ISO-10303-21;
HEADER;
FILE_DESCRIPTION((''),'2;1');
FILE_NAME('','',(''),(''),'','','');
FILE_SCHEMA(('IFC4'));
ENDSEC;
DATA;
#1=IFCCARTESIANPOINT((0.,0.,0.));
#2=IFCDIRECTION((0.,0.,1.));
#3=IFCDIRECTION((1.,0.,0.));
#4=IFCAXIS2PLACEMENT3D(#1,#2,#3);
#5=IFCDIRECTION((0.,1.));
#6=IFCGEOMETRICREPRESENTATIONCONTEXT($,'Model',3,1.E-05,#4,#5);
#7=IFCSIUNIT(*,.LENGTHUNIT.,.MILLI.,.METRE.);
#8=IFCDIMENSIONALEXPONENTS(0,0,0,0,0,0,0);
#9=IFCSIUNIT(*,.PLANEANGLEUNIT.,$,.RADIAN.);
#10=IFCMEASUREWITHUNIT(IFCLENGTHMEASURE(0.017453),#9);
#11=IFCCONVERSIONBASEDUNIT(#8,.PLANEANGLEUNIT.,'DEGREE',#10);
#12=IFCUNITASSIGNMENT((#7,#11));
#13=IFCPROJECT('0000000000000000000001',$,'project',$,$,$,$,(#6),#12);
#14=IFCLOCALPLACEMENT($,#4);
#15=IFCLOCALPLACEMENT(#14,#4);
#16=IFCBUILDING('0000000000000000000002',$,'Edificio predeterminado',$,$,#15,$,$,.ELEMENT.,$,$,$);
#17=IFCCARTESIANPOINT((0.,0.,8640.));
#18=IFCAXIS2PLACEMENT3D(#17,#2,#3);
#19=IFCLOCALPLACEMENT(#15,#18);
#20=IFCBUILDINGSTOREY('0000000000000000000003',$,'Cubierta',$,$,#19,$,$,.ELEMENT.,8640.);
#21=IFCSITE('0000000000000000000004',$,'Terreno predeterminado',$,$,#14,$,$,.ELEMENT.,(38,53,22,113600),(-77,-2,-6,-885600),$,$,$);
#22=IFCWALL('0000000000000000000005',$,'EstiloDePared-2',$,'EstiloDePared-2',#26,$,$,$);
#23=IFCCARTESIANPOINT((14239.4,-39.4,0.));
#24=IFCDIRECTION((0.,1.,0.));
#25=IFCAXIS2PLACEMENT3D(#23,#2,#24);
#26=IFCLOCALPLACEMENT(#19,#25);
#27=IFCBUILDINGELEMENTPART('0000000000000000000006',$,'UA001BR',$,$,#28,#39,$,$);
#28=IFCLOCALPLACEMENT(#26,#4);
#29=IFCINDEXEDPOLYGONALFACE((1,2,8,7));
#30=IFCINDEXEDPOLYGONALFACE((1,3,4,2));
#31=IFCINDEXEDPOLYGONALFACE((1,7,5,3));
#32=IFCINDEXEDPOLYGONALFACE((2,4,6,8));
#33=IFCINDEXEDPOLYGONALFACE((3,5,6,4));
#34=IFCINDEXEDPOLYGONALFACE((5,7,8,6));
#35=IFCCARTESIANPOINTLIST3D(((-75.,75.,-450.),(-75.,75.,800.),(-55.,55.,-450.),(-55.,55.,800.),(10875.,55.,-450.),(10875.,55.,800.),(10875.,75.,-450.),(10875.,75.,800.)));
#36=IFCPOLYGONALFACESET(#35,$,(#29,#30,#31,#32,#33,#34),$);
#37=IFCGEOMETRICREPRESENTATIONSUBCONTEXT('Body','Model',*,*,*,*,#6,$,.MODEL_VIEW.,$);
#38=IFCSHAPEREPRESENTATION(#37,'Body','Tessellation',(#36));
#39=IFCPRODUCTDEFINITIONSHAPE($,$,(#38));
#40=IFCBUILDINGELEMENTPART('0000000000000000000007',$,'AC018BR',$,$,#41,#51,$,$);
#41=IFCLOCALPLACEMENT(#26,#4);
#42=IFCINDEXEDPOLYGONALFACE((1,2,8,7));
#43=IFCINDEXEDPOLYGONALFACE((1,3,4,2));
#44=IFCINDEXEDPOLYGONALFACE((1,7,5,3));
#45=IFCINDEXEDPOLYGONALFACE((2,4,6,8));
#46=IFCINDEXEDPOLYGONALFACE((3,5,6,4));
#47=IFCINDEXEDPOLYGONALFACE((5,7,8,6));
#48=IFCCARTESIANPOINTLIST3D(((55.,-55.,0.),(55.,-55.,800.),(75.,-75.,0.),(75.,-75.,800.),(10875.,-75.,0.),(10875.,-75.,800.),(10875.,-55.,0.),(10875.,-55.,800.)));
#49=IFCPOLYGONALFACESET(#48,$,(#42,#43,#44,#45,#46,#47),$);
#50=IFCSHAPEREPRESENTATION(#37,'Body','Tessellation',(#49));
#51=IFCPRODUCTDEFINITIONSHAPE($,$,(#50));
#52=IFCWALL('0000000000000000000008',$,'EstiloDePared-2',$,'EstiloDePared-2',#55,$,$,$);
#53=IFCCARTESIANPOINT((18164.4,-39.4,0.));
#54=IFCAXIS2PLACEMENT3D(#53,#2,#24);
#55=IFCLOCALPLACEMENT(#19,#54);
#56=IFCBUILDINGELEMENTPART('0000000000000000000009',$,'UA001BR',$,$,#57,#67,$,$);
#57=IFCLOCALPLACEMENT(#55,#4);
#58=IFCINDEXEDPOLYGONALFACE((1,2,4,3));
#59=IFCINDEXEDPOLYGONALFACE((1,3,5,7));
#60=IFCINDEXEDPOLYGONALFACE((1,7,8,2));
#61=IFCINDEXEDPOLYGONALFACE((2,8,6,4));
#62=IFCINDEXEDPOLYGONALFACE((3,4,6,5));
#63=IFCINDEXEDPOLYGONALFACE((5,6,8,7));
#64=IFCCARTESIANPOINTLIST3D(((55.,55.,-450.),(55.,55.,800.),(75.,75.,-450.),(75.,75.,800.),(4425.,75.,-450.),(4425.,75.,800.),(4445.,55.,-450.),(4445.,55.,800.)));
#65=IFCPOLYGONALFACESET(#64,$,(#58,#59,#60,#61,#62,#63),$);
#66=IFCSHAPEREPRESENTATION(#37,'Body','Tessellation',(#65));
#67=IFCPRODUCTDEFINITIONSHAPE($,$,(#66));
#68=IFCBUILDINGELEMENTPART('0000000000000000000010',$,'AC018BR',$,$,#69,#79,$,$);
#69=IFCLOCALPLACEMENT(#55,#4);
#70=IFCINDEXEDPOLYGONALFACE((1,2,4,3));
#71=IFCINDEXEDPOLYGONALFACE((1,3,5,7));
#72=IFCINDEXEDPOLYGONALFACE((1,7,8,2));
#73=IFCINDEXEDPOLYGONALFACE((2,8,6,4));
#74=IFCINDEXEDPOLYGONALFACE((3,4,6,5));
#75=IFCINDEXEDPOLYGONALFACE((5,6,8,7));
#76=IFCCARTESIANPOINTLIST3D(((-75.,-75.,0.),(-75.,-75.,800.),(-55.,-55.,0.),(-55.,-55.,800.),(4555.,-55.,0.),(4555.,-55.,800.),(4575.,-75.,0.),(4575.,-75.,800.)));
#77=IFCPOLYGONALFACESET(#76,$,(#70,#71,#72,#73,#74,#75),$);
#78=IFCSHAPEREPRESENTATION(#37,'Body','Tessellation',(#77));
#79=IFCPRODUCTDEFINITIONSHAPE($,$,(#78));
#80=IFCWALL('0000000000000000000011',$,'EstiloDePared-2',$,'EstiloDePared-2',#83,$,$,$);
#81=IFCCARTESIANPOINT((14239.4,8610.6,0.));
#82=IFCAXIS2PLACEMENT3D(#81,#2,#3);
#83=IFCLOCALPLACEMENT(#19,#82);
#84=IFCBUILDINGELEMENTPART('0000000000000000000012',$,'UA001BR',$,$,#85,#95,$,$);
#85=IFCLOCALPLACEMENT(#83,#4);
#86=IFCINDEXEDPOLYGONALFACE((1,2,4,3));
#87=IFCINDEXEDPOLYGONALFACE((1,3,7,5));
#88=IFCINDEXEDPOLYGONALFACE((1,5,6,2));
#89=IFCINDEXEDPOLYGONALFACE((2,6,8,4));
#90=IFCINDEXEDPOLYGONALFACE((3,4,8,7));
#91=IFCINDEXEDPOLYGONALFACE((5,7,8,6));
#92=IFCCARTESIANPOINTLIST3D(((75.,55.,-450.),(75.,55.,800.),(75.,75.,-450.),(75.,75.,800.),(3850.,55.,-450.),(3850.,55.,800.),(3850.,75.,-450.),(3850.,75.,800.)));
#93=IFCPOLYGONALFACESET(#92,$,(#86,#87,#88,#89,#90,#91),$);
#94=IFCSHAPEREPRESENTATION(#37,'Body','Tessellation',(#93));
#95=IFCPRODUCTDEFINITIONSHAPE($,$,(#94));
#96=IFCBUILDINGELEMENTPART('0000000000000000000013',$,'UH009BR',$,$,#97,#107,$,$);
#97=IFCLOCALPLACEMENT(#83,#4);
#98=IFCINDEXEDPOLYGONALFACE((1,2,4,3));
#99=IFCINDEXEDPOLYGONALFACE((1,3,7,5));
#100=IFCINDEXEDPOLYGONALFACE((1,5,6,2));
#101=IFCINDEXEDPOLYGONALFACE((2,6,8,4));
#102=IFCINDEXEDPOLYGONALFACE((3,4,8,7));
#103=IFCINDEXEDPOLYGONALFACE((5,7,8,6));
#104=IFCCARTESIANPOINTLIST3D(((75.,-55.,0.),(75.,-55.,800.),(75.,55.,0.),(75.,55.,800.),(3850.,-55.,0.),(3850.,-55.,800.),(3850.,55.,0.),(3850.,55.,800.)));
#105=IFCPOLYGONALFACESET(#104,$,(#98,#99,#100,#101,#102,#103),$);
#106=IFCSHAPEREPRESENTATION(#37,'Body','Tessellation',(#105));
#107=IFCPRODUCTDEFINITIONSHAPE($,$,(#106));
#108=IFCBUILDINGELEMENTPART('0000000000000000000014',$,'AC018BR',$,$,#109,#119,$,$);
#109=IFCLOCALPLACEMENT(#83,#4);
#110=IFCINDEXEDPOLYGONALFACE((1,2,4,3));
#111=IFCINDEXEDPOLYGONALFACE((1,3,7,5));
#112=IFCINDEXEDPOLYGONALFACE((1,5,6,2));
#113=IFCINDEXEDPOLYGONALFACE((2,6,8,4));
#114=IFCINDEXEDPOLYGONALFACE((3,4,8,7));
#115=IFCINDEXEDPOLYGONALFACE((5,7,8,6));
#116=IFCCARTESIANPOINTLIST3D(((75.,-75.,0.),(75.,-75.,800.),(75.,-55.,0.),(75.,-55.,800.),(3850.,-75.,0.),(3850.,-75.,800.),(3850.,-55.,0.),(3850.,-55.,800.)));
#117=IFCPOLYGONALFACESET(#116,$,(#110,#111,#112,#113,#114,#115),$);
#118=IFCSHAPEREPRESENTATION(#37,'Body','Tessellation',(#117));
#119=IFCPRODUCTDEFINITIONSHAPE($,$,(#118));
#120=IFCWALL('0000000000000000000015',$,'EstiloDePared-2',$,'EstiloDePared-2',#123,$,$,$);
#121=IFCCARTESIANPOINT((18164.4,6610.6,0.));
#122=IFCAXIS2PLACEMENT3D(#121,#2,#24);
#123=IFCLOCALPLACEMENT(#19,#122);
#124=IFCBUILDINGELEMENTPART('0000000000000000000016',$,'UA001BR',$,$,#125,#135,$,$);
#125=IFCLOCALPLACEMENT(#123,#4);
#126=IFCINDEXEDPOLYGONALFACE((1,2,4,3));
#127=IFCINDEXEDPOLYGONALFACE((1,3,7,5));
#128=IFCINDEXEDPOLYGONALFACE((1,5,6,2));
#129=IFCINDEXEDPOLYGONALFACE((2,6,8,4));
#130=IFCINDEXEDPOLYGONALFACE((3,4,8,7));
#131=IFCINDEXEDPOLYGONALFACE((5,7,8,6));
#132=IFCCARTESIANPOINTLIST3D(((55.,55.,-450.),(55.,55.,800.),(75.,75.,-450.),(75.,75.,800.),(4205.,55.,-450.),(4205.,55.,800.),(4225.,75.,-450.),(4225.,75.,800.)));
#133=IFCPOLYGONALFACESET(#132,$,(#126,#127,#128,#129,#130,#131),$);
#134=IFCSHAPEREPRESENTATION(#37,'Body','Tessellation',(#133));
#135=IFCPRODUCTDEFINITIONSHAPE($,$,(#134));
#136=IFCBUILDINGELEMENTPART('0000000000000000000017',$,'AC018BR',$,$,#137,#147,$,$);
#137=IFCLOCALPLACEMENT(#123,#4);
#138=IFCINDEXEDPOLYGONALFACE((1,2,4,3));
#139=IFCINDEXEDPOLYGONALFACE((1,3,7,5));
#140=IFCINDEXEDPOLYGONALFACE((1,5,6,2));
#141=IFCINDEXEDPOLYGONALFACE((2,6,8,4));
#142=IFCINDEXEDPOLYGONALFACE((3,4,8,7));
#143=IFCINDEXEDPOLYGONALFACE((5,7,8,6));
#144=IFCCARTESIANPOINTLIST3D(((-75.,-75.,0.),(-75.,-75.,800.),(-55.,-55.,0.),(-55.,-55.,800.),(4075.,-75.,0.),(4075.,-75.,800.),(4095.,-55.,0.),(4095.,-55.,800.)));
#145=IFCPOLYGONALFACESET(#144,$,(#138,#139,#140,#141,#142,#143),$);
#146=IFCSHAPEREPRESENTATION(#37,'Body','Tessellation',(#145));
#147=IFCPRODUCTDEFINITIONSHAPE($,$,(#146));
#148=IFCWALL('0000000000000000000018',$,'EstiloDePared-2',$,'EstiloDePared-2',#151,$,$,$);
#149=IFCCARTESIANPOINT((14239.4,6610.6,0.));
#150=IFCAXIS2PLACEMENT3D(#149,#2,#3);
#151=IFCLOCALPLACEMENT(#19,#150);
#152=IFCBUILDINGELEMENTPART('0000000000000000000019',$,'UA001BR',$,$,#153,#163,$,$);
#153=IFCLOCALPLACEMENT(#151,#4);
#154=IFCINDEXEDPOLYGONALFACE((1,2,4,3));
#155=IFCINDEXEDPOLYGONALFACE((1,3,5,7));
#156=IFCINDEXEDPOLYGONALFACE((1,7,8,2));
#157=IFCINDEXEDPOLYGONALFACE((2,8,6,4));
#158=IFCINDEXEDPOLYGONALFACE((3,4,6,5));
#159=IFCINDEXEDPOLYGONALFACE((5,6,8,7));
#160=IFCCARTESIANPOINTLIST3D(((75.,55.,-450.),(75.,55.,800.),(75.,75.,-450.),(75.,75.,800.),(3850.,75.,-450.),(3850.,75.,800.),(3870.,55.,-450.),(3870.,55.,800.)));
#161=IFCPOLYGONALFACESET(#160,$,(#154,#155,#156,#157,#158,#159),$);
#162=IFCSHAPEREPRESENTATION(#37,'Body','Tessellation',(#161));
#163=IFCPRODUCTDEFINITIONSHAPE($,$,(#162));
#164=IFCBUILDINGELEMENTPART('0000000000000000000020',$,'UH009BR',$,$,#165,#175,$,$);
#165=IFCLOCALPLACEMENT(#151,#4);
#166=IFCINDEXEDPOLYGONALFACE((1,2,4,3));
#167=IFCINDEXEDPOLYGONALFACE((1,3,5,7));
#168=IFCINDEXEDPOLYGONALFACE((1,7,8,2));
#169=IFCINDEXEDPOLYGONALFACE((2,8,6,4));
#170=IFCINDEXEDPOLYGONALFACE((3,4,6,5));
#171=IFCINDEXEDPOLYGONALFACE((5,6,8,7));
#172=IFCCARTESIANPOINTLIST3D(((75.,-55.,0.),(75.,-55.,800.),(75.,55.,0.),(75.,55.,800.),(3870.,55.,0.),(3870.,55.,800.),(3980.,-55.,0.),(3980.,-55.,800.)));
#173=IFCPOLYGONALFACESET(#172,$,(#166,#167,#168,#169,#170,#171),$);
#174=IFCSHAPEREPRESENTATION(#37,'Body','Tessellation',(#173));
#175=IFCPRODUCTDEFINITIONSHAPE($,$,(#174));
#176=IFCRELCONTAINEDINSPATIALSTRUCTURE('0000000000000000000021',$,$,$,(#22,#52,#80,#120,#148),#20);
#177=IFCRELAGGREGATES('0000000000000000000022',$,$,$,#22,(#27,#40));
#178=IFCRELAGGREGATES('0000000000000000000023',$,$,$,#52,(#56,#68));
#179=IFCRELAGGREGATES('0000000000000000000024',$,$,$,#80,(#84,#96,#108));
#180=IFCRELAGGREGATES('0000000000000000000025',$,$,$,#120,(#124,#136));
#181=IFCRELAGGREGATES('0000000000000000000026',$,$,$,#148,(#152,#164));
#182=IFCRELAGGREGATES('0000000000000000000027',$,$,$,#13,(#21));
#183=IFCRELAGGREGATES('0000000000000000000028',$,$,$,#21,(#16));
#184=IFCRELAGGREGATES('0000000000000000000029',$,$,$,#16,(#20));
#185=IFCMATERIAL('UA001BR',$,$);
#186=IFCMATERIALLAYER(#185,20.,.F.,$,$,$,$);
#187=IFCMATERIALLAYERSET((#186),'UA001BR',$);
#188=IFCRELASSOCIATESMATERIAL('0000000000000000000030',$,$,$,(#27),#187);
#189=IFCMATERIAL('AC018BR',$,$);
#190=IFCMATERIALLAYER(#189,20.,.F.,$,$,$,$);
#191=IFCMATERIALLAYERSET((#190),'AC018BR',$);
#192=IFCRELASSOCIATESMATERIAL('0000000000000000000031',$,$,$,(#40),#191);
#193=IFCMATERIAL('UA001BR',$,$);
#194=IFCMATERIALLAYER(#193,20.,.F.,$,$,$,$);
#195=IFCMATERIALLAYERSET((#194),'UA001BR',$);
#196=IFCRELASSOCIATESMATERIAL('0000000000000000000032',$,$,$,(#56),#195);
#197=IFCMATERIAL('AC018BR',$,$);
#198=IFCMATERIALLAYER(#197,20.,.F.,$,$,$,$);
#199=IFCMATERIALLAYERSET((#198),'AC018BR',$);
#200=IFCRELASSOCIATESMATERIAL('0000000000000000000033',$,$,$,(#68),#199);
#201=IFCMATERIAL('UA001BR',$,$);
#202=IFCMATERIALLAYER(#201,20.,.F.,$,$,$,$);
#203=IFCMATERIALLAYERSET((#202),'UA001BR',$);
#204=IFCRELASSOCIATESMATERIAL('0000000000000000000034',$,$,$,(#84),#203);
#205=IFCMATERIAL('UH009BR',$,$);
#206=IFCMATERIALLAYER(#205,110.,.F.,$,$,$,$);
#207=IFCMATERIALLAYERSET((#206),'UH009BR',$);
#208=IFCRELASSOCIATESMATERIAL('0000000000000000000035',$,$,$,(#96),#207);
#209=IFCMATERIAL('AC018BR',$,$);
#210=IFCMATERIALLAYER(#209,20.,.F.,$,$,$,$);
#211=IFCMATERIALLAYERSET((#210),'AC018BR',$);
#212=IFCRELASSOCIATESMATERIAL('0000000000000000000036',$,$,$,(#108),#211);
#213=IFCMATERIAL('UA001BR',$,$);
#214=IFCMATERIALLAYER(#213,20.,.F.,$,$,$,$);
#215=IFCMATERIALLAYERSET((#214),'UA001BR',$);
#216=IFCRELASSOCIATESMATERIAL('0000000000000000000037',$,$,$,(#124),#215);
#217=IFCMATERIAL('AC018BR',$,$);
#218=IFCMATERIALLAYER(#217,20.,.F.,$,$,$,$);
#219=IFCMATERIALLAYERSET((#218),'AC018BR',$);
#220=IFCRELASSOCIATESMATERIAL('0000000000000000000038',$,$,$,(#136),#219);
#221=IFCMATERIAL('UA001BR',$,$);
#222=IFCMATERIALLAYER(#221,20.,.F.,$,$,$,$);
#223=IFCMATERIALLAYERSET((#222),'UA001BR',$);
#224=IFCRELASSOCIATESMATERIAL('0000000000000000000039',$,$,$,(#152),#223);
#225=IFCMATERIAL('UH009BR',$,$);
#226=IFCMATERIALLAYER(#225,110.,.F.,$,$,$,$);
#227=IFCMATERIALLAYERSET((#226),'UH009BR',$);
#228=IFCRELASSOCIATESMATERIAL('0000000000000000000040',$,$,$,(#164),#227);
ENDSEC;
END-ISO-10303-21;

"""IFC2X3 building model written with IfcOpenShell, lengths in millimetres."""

from ifc_helpers import new_model, entity, si_unit, converted_unit, direction, frame, origin_with_axes, place, context, subcontext, project, spatial, polyline, outline, extrude, material, layer, layer_set, layer_usage, element, aggregate, save


model = new_model("IFC2X3")

# Units and contexts
model_context = context("Model", 3, precision=1e-05, world=origin_with_axes(), true_north=direction((0.0, 1.0)))
body_context = subcontext(model_context, "Body", "Model", "MODEL_VIEW")
ifc_project = project(units=[si_unit("LENGTHUNIT", "METRE", prefix="MILLI"), converted_unit("PLANEANGLEUNIT", "DEGREE", entity("IfcLengthMeasure", 0.017453), si_unit("PLANEANGLEUNIT", "RADIAN"), dimensions=[0, 0, 0, 0, 0, 0, 0])], contexts=[model_context])

# Site, building, storey
site_placement = place(None, origin_with_axes())
site = spatial("IfcSite", under=ifc_project, at=site_placement, Name="Terreno predeterminado", CompositionType="ELEMENT", RefLatitude=(38, 53, 22, 113600), RefLongitude=(-77, -2, -6, -885600))
building_placement = place(site_placement, origin_with_axes())
building = spatial("IfcBuilding", under=site, at=building_placement, Name="Edificio predeterminado", CompositionType="ELEMENT")
storey_placement = place(building_placement, frame((0.0, 0.0, 8640.0), z_axis=(0.0, 0.0, 1.0), x_axis=(1.0, 0.0, 0.0)))
storey = spatial("IfcBuildingStorey", under=building, at=storey_placement, Name="Cubierta", CompositionType="ELEMENT", Elevation=8640.0)

# Walls, building element parts
wall_1_placement = place(storey_placement, frame((14239.4, -39.4, 0.0), z_axis=(0.0, 0.0, 1.0), x_axis=(0.0, 1.0, 0.0)))
wall_1 = element("IfcWall", 1, at=wall_1_placement, inside=storey, Name="EstiloDePared-2", ObjectType="EstiloDePared-2")
ifc_material_1 = material(Name="UA001BR")
ifc_layer_1 = layer(ifc_material_1, 20.0, ventilated=False)
ifc_layer_set_1 = layer_set([ifc_layer_1], Name="UA001BR")
ifc_layer_usage_1 = layer_usage(ifc_layer_set_1, "AXIS2", "NEGATIVE", -75.0)
building_element_part_1_placement = place(wall_1_placement, origin_with_axes())
building_element_part_1 = element("IfcBuildingElementPart", 2, at=building_element_part_1_placement, material=ifc_layer_usage_1, Name="UA001BR", context=body_context, shape_type="SweptSolid", body=[
    extrude(outline(polyline([(10875.0, 75.0), (10875.0, 55.0), (-55.0, 55.0), (-75.0, 75.0), (10875.0, 75.0)])), frame((0.0, 0.0, -450.0), z_axis=(0.0, 0.0, 1.0), x_axis=(1.0, 0.0, 0.0)), (0.0, 0.0, 1.0), 1250.0),
])
ifc_material_2 = material(Name="AC018BR")
ifc_layer_2 = layer(ifc_material_2, 20.0, ventilated=False)
ifc_layer_set_2 = layer_set([ifc_layer_2], Name="AC018BR")
ifc_layer_usage_2 = layer_usage(ifc_layer_set_2, "AXIS2", "NEGATIVE", 55.0)
building_element_part_2_placement = place(wall_1_placement, origin_with_axes())
building_element_part_2 = element("IfcBuildingElementPart", 3, at=building_element_part_2_placement, material=ifc_layer_usage_2, Name="AC018BR", context=body_context, shape_type="SweptSolid", body=[
    extrude(outline(polyline([(10875.0, -55.0), (10875.0, -75.0), (75.0, -75.0), (55.0, -55.0), (10875.0, -55.0)])), origin_with_axes(), (0.0, 0.0, 1.0), 800.0),
])
aggregate(wall_1, [building_element_part_1, building_element_part_2])
wall_2_placement = place(storey_placement, frame((18164.4, -39.4, 0.0), z_axis=(0.0, 0.0, 1.0), x_axis=(0.0, 1.0, 0.0)))
wall_2 = element("IfcWall", 4, at=wall_2_placement, inside=storey, Name="EstiloDePared-2", ObjectType="EstiloDePared-2")
ifc_material_3 = material(Name="UA001BR")
ifc_layer_3 = layer(ifc_material_3, 20.0, ventilated=False)
ifc_layer_set_3 = layer_set([ifc_layer_3], Name="UA001BR")
ifc_layer_usage_3 = layer_usage(ifc_layer_set_3, "AXIS2", "NEGATIVE", -75.0)
building_element_part_3_placement = place(wall_2_placement, origin_with_axes())
building_element_part_3 = element("IfcBuildingElementPart", 5, at=building_element_part_3_placement, material=ifc_layer_usage_3, Name="UA001BR", context=body_context, shape_type="SweptSolid", body=[
    extrude(outline(polyline([(4425.0, 75.0), (4445.0, 55.0), (55.0, 55.0), (75.0, 75.0), (4425.0, 75.0)])), frame((0.0, 0.0, -450.0), z_axis=(0.0, 0.0, 1.0), x_axis=(1.0, 0.0, 0.0)), (0.0, 0.0, 1.0), 1250.0),
])
ifc_material_4 = material(Name="AC018BR")
ifc_layer_4 = layer(ifc_material_4, 20.0, ventilated=False)
ifc_layer_set_4 = layer_set([ifc_layer_4], Name="AC018BR")
ifc_layer_usage_4 = layer_usage(ifc_layer_set_4, "AXIS2", "NEGATIVE", 55.0)
building_element_part_4_placement = place(wall_2_placement, origin_with_axes())
building_element_part_4 = element("IfcBuildingElementPart", 6, at=building_element_part_4_placement, material=ifc_layer_usage_4, Name="AC018BR", context=body_context, shape_type="SweptSolid", body=[
    extrude(outline(polyline([(4555.0, -55.0), (4575.0, -75.0), (-75.0, -75.0), (-55.0, -55.0), (4555.0, -55.0)])), origin_with_axes(), (0.0, 0.0, 1.0), 800.0),
])
aggregate(wall_2, [building_element_part_3, building_element_part_4])
wall_3_placement = place(storey_placement, frame((14239.4, 8610.6, 0.0), z_axis=(0.0, 0.0, 1.0), x_axis=(1.0, 0.0, 0.0)))
wall_3 = element("IfcWall", 7, at=wall_3_placement, inside=storey, Name="EstiloDePared-2", ObjectType="EstiloDePared-2")
ifc_material_5 = material(Name="UA001BR")
ifc_layer_5 = layer(ifc_material_5, 20.0, ventilated=False)
ifc_layer_set_5 = layer_set([ifc_layer_5], Name="UA001BR")
ifc_layer_usage_5 = layer_usage(ifc_layer_set_5, "AXIS2", "NEGATIVE", -75.0)
building_element_part_5_placement = place(wall_3_placement, origin_with_axes())
building_element_part_5 = element("IfcBuildingElementPart", 8, at=building_element_part_5_placement, material=ifc_layer_usage_5, Name="UA001BR", context=body_context, shape_type="SweptSolid", body=[
    extrude(outline(polyline([(3850.0, 75.0), (3850.0, 55.0), (75.0, 55.0), (75.0, 75.0), (3850.0, 75.0)])), frame((0.0, 0.0, -450.0), z_axis=(0.0, 0.0, 1.0), x_axis=(1.0, 0.0, 0.0)), (0.0, 0.0, 1.0), 1250.0),
])
ifc_material_6 = material(Name="UH009BR")
ifc_layer_6 = layer(ifc_material_6, 110.0, ventilated=False)
ifc_layer_set_6 = layer_set([ifc_layer_6], Name="UH009BR")
ifc_layer_usage_6 = layer_usage(ifc_layer_set_6, "AXIS2", "NEGATIVE", -55.0)
building_element_part_6_placement = place(wall_3_placement, origin_with_axes())
building_element_part_6 = element("IfcBuildingElementPart", 9, at=building_element_part_6_placement, material=ifc_layer_usage_6, Name="UH009BR", context=body_context, shape_type="SweptSolid", body=[
    extrude(outline(polyline([(3850.0, 55.0), (3850.0, -55.0), (75.0, -55.0), (75.0, 55.0), (3850.0, 55.0)])), origin_with_axes(), (0.0, 0.0, 1.0), 800.0),
])
ifc_material_7 = material(Name="AC018BR")
ifc_layer_7 = layer(ifc_material_7, 20.0, ventilated=False)
ifc_layer_set_7 = layer_set([ifc_layer_7], Name="AC018BR")
ifc_layer_usage_7 = layer_usage(ifc_layer_set_7, "AXIS2", "NEGATIVE", 55.0)
building_element_part_7_placement = place(wall_3_placement, origin_with_axes())
building_element_part_7 = element("IfcBuildingElementPart", 10, at=building_element_part_7_placement, material=ifc_layer_usage_7, Name="AC018BR", context=body_context, shape_type="SweptSolid", body=[
    extrude(outline(polyline([(3850.0, -55.0), (3850.0, -75.0), (75.0, -75.0), (75.0, -55.0), (3850.0, -55.0)])), origin_with_axes(), (0.0, 0.0, 1.0), 800.0),
])
aggregate(wall_3, [building_element_part_5, building_element_part_6, building_element_part_7])
wall_4_placement = place(storey_placement, frame((18164.4, 6610.6, 0.0), z_axis=(0.0, 0.0, 1.0), x_axis=(0.0, 1.0, 0.0)))
wall_4 = element("IfcWall", 11, at=wall_4_placement, inside=storey, Name="EstiloDePared-2", ObjectType="EstiloDePared-2")
ifc_material_8 = material(Name="UA001BR")
ifc_layer_8 = layer(ifc_material_8, 20.0, ventilated=False)
ifc_layer_set_8 = layer_set([ifc_layer_8], Name="UA001BR")
ifc_layer_usage_8 = layer_usage(ifc_layer_set_8, "AXIS2", "NEGATIVE", -75.0)
building_element_part_8_placement = place(wall_4_placement, origin_with_axes())
building_element_part_8 = element("IfcBuildingElementPart", 12, at=building_element_part_8_placement, material=ifc_layer_usage_8, Name="UA001BR", context=body_context, shape_type="SweptSolid", body=[
    extrude(outline(polyline([(4225.0, 75.0), (4205.0, 55.0), (55.0, 55.0), (75.0, 75.0), (4225.0, 75.0)])), frame((0.0, 0.0, -450.0), z_axis=(0.0, 0.0, 1.0), x_axis=(1.0, 0.0, 0.0)), (0.0, 0.0, 1.0), 1250.0),
])
ifc_material_9 = material(Name="AC018BR")
ifc_layer_9 = layer(ifc_material_9, 20.0, ventilated=False)
ifc_layer_set_9 = layer_set([ifc_layer_9], Name="AC018BR")
ifc_layer_usage_9 = layer_usage(ifc_layer_set_9, "AXIS2", "NEGATIVE", 55.0)
building_element_part_9_placement = place(wall_4_placement, origin_with_axes())
building_element_part_9 = element("IfcBuildingElementPart", 13, at=building_element_part_9_placement, material=ifc_layer_usage_9, Name="AC018BR", context=body_context, shape_type="SweptSolid", body=[
    extrude(outline(polyline([(4095.0, -55.0), (4075.0, -75.0), (-75.0, -75.0), (-55.0, -55.0), (4095.0, -55.0)])), origin_with_axes(), (0.0, 0.0, 1.0), 800.0),
])
aggregate(wall_4, [building_element_part_8, building_element_part_9])
wall_5_placement = place(storey_placement, frame((14239.4, 6610.6, 0.0), z_axis=(0.0, 0.0, 1.0), x_axis=(1.0, 0.0, 0.0)))
wall_5 = element("IfcWall", 14, at=wall_5_placement, inside=storey, Name="EstiloDePared-2", ObjectType="EstiloDePared-2")
ifc_material_10 = material(Name="UA001BR")
ifc_layer_10 = layer(ifc_material_10, 20.0, ventilated=False)
ifc_layer_set_10 = layer_set([ifc_layer_10], Name="UA001BR")
ifc_layer_usage_10 = layer_usage(ifc_layer_set_10, "AXIS2", "NEGATIVE", -75.0)
building_element_part_10_placement = place(wall_5_placement, origin_with_axes())
building_element_part_10 = element("IfcBuildingElementPart", 15, at=building_element_part_10_placement, material=ifc_layer_usage_10, Name="UA001BR", context=body_context, shape_type="SweptSolid", body=[
    extrude(outline(polyline([(3850.0, 75.0), (3870.0, 55.0), (75.0, 55.0), (75.0, 75.0), (3850.0, 75.0)])), frame((0.0, 0.0, -450.0), z_axis=(0.0, 0.0, 1.0), x_axis=(1.0, 0.0, 0.0)), (0.0, 0.0, 1.0), 1250.0),
])
ifc_material_11 = material(Name="UH009BR")
ifc_layer_11 = layer(ifc_material_11, 110.0, ventilated=False)
ifc_layer_set_11 = layer_set([ifc_layer_11], Name="UH009BR")
ifc_layer_usage_11 = layer_usage(ifc_layer_set_11, "AXIS2", "NEGATIVE", -55.0)
building_element_part_11_placement = place(wall_5_placement, origin_with_axes())
building_element_part_11 = element("IfcBuildingElementPart", 16, at=building_element_part_11_placement, material=ifc_layer_usage_11, Name="UH009BR", context=body_context, shape_type="SweptSolid", body=[
    extrude(outline(polyline([(3870.0, 55.0), (3980.0, -55.0), (75.0, -55.0), (75.0, 55.0), (3870.0, 55.0)])), origin_with_axes(), (0.0, 0.0, 1.0), 800.0),
])
aggregate(wall_5, [building_element_part_10, building_element_part_11])

save(model, "model.ifc")
